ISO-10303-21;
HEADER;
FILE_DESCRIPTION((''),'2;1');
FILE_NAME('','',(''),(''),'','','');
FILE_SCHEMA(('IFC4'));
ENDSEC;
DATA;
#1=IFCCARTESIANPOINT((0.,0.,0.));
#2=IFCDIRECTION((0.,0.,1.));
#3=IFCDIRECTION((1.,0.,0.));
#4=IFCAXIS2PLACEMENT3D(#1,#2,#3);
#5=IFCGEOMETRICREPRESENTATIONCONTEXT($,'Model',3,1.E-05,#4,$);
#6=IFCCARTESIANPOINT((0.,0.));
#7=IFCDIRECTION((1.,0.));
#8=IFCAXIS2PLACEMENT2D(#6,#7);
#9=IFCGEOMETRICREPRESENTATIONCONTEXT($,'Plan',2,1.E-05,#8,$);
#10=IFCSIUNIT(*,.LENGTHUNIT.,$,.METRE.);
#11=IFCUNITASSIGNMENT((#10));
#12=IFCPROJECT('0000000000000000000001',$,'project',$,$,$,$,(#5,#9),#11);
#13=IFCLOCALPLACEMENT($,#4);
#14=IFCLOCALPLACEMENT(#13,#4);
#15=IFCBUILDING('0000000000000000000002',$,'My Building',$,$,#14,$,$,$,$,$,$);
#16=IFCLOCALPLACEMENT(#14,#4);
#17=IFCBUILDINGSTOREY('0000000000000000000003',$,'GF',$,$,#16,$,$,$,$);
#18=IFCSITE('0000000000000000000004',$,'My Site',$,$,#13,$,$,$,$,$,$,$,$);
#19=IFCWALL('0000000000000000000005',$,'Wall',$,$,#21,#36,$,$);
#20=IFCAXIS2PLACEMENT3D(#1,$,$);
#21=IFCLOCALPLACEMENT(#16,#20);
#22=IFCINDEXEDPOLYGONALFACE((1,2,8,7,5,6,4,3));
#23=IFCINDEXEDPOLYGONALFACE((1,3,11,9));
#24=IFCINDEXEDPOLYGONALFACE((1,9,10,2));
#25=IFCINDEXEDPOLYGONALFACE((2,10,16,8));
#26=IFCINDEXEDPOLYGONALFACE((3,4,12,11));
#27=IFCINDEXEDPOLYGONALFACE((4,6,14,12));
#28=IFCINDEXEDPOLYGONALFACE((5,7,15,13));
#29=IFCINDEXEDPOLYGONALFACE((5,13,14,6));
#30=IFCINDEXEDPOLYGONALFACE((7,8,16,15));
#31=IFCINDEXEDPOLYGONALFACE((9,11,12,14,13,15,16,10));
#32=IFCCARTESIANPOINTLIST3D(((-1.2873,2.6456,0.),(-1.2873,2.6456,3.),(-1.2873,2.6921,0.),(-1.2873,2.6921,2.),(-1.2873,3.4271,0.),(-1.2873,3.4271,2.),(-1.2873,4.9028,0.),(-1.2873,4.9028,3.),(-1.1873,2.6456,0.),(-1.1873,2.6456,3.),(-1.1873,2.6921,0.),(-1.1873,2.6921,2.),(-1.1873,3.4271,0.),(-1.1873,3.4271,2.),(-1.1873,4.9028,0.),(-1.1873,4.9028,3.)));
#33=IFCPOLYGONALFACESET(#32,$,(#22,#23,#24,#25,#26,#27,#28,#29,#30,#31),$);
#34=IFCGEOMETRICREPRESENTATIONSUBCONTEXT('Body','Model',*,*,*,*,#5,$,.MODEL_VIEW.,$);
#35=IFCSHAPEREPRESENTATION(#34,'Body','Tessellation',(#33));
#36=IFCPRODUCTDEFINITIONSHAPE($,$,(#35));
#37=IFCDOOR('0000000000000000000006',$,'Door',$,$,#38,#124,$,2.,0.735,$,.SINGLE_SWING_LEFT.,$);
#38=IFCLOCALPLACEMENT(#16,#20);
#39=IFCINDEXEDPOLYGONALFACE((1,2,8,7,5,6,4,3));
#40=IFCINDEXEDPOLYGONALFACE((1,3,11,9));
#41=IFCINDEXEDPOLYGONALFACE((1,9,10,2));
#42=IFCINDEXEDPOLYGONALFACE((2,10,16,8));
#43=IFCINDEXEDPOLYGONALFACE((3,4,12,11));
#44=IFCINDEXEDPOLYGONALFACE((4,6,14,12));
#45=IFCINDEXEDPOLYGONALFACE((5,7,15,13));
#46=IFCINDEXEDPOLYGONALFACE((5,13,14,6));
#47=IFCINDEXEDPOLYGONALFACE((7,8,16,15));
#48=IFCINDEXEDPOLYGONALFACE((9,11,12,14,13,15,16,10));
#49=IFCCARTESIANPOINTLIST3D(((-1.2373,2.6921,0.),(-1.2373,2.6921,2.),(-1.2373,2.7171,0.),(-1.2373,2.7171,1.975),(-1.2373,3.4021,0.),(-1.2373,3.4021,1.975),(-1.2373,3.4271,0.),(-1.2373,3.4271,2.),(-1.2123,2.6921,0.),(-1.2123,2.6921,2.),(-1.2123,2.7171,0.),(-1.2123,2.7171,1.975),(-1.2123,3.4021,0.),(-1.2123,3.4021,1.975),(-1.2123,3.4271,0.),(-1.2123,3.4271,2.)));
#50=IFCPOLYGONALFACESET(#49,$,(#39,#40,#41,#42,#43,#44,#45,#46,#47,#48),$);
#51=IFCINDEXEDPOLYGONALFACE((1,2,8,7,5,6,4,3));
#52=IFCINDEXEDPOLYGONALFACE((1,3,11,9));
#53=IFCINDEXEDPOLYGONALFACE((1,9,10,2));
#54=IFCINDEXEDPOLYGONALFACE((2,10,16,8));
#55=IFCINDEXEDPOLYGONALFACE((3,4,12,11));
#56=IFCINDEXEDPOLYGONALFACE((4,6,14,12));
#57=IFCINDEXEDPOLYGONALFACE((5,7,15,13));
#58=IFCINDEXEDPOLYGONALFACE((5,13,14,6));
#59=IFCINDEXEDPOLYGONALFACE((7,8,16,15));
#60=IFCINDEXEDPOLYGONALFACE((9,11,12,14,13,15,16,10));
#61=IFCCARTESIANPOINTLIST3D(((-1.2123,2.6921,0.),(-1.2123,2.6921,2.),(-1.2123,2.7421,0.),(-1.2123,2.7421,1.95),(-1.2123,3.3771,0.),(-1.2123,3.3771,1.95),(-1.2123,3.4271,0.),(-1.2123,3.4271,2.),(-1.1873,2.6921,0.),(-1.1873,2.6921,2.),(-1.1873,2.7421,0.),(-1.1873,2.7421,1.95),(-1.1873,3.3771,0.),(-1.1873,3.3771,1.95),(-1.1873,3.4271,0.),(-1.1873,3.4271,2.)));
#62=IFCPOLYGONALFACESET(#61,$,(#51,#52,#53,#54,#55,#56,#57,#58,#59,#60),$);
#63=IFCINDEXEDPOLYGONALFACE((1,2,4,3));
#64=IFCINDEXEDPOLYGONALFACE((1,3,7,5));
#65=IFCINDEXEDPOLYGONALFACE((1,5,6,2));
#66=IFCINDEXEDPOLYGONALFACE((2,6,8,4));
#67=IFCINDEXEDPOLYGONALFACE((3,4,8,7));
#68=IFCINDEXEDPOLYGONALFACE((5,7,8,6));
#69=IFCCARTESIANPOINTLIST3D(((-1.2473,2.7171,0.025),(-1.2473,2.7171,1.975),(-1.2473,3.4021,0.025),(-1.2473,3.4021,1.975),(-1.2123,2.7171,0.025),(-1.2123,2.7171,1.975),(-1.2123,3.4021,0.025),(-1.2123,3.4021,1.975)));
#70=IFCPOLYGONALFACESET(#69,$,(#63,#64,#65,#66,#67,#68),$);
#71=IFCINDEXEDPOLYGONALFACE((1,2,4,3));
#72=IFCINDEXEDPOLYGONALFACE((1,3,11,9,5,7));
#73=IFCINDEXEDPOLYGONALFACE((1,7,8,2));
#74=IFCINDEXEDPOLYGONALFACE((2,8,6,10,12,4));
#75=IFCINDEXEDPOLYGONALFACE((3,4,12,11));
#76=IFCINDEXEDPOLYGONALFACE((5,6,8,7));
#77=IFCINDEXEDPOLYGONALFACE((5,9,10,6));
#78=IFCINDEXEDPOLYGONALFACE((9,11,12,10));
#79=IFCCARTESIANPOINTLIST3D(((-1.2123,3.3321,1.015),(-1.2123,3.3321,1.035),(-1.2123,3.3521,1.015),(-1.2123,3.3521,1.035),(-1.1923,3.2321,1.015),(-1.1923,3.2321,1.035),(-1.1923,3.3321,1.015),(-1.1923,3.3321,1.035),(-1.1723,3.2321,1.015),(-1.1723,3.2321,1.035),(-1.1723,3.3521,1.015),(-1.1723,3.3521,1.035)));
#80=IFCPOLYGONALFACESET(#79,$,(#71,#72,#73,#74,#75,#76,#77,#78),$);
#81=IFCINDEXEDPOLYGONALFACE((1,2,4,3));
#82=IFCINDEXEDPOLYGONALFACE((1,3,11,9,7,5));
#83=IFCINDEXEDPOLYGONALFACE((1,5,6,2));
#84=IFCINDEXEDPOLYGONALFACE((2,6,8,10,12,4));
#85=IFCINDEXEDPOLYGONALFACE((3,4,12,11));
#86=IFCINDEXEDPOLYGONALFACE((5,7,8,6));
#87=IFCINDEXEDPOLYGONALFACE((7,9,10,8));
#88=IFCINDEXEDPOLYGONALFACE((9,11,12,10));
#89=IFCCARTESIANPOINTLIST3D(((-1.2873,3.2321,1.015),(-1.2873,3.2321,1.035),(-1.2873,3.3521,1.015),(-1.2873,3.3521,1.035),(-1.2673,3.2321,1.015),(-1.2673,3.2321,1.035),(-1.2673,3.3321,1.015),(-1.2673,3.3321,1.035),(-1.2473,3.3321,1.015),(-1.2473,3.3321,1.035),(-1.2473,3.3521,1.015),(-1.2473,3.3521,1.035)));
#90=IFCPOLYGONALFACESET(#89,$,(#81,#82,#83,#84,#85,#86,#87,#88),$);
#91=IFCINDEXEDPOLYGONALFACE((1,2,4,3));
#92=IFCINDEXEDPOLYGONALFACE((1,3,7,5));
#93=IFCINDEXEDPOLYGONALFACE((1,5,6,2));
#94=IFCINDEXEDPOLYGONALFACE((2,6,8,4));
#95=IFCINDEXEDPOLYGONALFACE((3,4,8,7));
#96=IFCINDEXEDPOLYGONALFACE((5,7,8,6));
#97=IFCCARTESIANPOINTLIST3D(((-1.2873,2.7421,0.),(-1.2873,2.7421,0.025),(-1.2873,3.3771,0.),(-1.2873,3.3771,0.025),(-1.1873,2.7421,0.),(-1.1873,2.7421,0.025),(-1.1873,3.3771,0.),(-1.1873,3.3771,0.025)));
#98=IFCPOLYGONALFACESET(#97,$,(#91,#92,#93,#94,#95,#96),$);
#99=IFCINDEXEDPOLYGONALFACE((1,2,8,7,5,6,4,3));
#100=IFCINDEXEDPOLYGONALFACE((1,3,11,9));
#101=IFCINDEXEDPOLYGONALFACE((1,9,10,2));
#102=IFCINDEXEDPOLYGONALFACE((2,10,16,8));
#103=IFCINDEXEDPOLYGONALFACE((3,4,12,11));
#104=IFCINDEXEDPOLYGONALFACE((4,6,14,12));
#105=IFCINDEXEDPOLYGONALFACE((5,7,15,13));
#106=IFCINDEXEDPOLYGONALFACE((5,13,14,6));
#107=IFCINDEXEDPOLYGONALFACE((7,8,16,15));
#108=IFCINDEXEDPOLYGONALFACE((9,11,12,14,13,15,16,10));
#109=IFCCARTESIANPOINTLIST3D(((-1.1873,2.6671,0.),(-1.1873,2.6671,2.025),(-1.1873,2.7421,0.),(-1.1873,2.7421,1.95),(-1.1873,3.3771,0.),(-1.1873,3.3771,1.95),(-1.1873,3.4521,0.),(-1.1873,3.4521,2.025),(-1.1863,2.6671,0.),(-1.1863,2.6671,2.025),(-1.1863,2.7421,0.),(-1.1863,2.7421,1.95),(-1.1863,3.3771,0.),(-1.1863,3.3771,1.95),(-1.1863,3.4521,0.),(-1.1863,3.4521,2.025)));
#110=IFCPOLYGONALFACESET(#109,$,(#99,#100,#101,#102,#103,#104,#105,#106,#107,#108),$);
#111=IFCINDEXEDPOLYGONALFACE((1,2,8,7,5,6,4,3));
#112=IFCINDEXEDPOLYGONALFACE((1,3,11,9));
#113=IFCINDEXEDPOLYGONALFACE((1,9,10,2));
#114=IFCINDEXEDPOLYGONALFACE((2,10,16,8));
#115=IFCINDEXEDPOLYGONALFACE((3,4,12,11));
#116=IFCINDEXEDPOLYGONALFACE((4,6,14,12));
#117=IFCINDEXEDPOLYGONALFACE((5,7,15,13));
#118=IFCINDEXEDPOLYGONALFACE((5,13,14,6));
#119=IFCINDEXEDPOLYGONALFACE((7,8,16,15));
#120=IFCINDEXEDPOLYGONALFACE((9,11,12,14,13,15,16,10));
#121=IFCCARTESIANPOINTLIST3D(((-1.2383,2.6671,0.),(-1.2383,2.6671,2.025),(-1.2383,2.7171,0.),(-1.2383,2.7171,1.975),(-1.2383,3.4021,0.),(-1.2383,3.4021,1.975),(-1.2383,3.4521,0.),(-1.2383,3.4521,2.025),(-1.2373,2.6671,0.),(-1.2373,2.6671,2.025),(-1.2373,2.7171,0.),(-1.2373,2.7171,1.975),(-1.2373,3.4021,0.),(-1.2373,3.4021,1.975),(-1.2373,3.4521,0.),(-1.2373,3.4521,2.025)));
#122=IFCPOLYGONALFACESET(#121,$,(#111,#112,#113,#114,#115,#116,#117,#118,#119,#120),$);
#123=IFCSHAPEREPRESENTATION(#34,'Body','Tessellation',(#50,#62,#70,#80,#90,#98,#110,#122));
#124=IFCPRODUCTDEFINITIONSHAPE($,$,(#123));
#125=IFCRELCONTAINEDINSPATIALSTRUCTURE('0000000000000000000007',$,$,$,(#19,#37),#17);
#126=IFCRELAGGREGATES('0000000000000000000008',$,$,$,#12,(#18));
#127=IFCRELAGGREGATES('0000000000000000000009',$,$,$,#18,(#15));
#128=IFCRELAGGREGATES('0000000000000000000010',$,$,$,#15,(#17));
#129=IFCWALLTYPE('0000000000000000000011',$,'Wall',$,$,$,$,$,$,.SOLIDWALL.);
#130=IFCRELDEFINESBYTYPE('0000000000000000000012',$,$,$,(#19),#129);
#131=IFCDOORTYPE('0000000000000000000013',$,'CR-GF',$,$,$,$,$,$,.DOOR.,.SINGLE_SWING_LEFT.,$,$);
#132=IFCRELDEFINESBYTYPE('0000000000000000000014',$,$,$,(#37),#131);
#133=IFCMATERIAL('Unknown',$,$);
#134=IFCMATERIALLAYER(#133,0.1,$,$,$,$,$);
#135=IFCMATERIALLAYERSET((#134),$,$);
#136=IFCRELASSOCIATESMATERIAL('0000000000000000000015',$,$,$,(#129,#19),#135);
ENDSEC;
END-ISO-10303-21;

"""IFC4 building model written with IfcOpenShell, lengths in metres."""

from ifc_helpers import new_model, entity, si_unit, frame, origin_with_axes, origin_2d_with_axis, place, context, subcontext, project, spatial, line, indexed_curve, outline, extrude, shape, source, transform, mapped, material, layer, layer_set, layer_usage, type_object, type_shapes, element, fill, save


model = new_model("IFC4")

# Units and contexts
model_context = context("Model", 3, precision=1e-05, world=origin_with_axes())
plan_context = context("Plan", 2, precision=1e-05, world=origin_2d_with_axis())
body_context_1 = subcontext(model_context, "Body", "Model", "MODEL_VIEW")
body_context_2 = subcontext(plan_context, "Body", "Plan", "PLAN_VIEW")
ifc_project = project(units=[si_unit("LENGTHUNIT", "METRE")], contexts=[model_context, plan_context])

# Site, building, storey
site_placement = place(None, origin_with_axes())
site = spatial("IfcSite", under=ifc_project, at=site_placement, Name="My Site")
building_placement = place(site_placement, origin_with_axes())
building = spatial("IfcBuilding", under=site, at=building_placement, Name="My Building")
storey_placement = place(building_placement, origin_with_axes())
storey = spatial("IfcBuildingStorey", under=building, at=storey_placement, Name="GF")

# Shared definitions
ifc_material = material(Name="Unknown")

# Shared definitions
ifc_layer_1 = layer(ifc_material, 0.1)
ifc_layer_set_1 = layer_set([ifc_layer_1])
wall_type = type_object("IfcWallType", Name="Wall", PredefinedType="SOLIDWALL", material=ifc_layer_set_1)

# Wall, opening, door
ifc_layer_usage_1 = layer_usage(ifc_layer_set_1, "AXIS2", "POSITIVE", 0.0)
wall_1_placement = place(storey_placement, frame((-1.1873, 2.5456, 0.0), z_axis=(0.0, 0.0, 1.0), x_axis=(0.0, 1.0, 0.0)))
wall_1 = element("IfcWall", 1, at=wall_1_placement, inside=storey, type_object=wall_type, material=ifc_layer_usage_1, Name="Wall", context=body_context_1, shape_type="SweptSolid", body=[
    extrude(outline(indexed_curve([(0.1, 0.0), (0.1, 0.1), (2.3572, 0.1), (2.3572, 0.0)], segments=[line(1, 2, 3, 4, 1)])), origin_with_axes(), (0.0, 0.0, 1.0), 3.0),
])
shared_shape_1 = source(origin_with_axes(), body_context_1, "Body", "SweptSolid", [
    extrude(outline(indexed_curve([(0.0, 0.0), (0.735, 0.0), (0.735, 2.0), (0.0, 2.0)], segments=[line(1, 2, 3, 4, 1)])), frame((0.0, -0.6, 0.0), z_axis=(0.0, -1.0, 0.0), x_axis=(1.0, 0.0, 0.0)), (0.0, 0.0, -1.0), 1.2),
])
opening_1_placement = place(wall_1_placement, frame((0.1466, 0.0, 0.0), z_axis=(0.0, 0.0, 1.0), x_axis=(1.0, 0.0, 0.0)))
opening_1 = element("IfcOpeningElement", 2, at=opening_1_placement, cuts=wall_1, PredefinedType="OPENING", context=body_context_1, shape_type="MappedRepresentation", body=[
    mapped(shared_shape_1, transform((0.0, 0.0, 0.0), x_axis=(1.0, 0.0, 0.0), y_axis=(0.0, 1.0, 0.0), z_axis=(0.0, 0.0, 1.0), scale=1.0)),
])
door_type_1 = type_object("IfcDoorType", Name="CR-GF", OperationType="SINGLE_SWING_LEFT", PredefinedType="DOOR")
shared_shape_2 = source(origin_with_axes(), body_context_1, "Body", "SweptSolid", [
    extrude(outline(indexed_curve([(0.0, 0.0), (0.0, 2.0), (0.735, 2.0), (0.735, 0.0), (0.71, 0.0), (0.71, 1.975), (0.025, 1.975), (0.025, 0.0)], segments=[line(1, 2, 3, 4, 5, 6, 7, 8, 1)])), frame((0.0, 0.025, 0.0), z_axis=(0.0, -1.0, 0.0), x_axis=(1.0, 0.0, 0.0)), (0.0, 0.0, -1.0), 0.025),
    extrude(outline(indexed_curve([(0.0, 0.0), (0.0, 2.0), (0.735, 2.0), (0.735, 0.0), (0.685, 0.0), (0.685, 1.95), (0.05, 1.95), (0.05, 0.0)], segments=[line(1, 2, 3, 4, 5, 6, 7, 8, 1)])), frame((0.0, 0.0, 0.0), z_axis=(0.0, -1.0, 0.0), x_axis=(1.0, 0.0, 0.0)), (0.0, 0.0, -1.0), 0.025),
    extrude(outline(indexed_curve([(0.0, 0.0), (0.685, 0.0), (0.685, 0.035), (0.0, 0.035)], segments=[line(1, 2, 3, 4, 1)])), frame((0.025, 0.025, 0.025), z_axis=(0.0, 0.0, 1.0), x_axis=(1.0, 0.0, 0.0)), (0.0, 0.0, 1.0), 1.95),
    extrude(outline(indexed_curve([(0.0, 0.0), (0.0, -0.04), (-0.12, -0.04), (-0.12, -0.02), (-0.02, -0.02), (-0.02, 0.0)], segments=[line(1, 2, 3, 4, 5, 6, 1)])), frame((0.66, 0.025, 1.015), z_axis=(0.0, 0.0, 1.0), x_axis=(1.0, 0.0, 0.0)), (0.0, 0.0, 1.0), 0.02),
    extrude(outline(indexed_curve([(0.0, 0.0), (0.0, 0.04), (-0.12, 0.04), (-0.12, 0.02), (-0.02, 0.02), (-0.02, 0.0)], segments=[line(1, 2, 3, 4, 5, 6, 1)])), frame((0.66, 0.06, 1.015), z_axis=(0.0, 0.0, 1.0), x_axis=(1.0, 0.0, 0.0)), (0.0, 0.0, 1.0), 0.02),
    extrude(outline(indexed_curve([(0.0, 0.0), (0.635, 0.0), (0.635, 0.1), (0.0, 0.1)], segments=[line(1, 2, 3, 4, 1)])), frame((0.05, 0.0, 0.0), z_axis=(0.0, 0.0, 1.0), x_axis=(1.0, 0.0, 0.0)), (0.0, 0.0, 1.0), 0.025),
    extrude(outline(indexed_curve([(0.0, 0.0), (0.0, 2.025), (0.785, 2.025), (0.785, 0.0), (0.71, 0.0), (0.71, 1.95), (0.075, 1.95), (0.075, 0.0)], segments=[line(1, 2, 3, 4, 5, 6, 7, 8, 1)])), frame((-0.025, -0.001, 0.0), z_axis=(0.0, -1.0, 0.0), x_axis=(1.0, 0.0, 0.0)), (0.0, 0.0, -1.0), 0.001),
    extrude(outline(indexed_curve([(0.0, 0.0), (0.0, 2.025), (0.785, 2.025), (0.785, 0.0), (0.735, 0.0), (0.735, 1.975), (0.05, 1.975), (0.05, 0.0)], segments=[line(1, 2, 3, 4, 5, 6, 7, 8, 1)])), frame((-0.025, 0.05, 0.0), z_axis=(0.0, -1.0, 0.0), x_axis=(1.0, 0.0, 0.0)), (0.0, 0.0, -1.0), 0.001),
])
shared_shape_3 = source(origin_with_axes(), body_context_2, "Body", "Curve2D", [
    entity("IfcIndexedPolyCurve", entity("IfcCartesianPointList2D", [[0.0, 0.0], [0.0, 0.05], [0.025, 0.05], [0.025, 0.025], [0.05, 0.025], [0.05, 0.0]]), [entity("IfcLineIndex", [1, 2, 3, 4, 5, 6, 1])]),
    entity("IfcIndexedPolyCurve", entity("IfcCartesianPointList2D", [[0.735, 0.0], [0.735, 0.05], [0.71, 0.05], [0.71, 0.025], [0.685, 0.025], [0.685, 0.0]]), [entity("IfcLineIndex", [1, 2, 3, 4, 5, 6, 1])]),
    entity("IfcTrimmedCurve", entity("IfcEllipse", entity("IfcAxis2Placement2D", entity("IfcCartesianPoint", [0.06, 0.05]), entity("IfcDirection", [1.0, 0.0])), 0.65, 0.685), [entity("IfcCartesianPoint", [0.71, 0.05])], [entity("IfcCartesianPoint", [0.06, 0.735])], True, "CARTESIAN"),
    entity("IfcIndexedPolyCurve", entity("IfcCartesianPointList2D", [[0.025, 0.05], [0.06, 0.05], [0.06, 0.735], [0.025, 0.735]]), [entity("IfcLineIndex", [1, 2, 3, 4, 1])]),
])
type_shapes(door_type_1, [shared_shape_2, shared_shape_3])
door_1_placement = place(opening_1_placement, frame((0.0, 0.0, 0.0), z_axis=(0.0, 0.0, 1.0), x_axis=(1.0, 0.0, 0.0)))
door_1 = element("IfcDoor", 3, at=door_1_placement, inside=storey, type_object=door_type_1, Name="Door", OperationType="SINGLE_SWING_LEFT", OverallHeight=2.0, OverallWidth=0.735, shapes=[
    shape(body_context_1, "Body", "MappedRepresentation", [mapped(shared_shape_2, transform((0.0, 0.0, 0.0), x_axis=(1.0, 0.0, 0.0), y_axis=(0.0, 1.0, 0.0), z_axis=(0.0, 0.0, 1.0), scale=1.0))]),
    shape(body_context_2, "Body", "MappedRepresentation", [mapped(shared_shape_3, transform((0.0, 0.0, 0.0), x_axis=(1.0, 0.0, 0.0), y_axis=(0.0, 1.0, 0.0), z_axis=(0.0, 0.0, 1.0), scale=1.0))]),
])
fill(opening_1, door_1)

save(model, "model.ifc")
